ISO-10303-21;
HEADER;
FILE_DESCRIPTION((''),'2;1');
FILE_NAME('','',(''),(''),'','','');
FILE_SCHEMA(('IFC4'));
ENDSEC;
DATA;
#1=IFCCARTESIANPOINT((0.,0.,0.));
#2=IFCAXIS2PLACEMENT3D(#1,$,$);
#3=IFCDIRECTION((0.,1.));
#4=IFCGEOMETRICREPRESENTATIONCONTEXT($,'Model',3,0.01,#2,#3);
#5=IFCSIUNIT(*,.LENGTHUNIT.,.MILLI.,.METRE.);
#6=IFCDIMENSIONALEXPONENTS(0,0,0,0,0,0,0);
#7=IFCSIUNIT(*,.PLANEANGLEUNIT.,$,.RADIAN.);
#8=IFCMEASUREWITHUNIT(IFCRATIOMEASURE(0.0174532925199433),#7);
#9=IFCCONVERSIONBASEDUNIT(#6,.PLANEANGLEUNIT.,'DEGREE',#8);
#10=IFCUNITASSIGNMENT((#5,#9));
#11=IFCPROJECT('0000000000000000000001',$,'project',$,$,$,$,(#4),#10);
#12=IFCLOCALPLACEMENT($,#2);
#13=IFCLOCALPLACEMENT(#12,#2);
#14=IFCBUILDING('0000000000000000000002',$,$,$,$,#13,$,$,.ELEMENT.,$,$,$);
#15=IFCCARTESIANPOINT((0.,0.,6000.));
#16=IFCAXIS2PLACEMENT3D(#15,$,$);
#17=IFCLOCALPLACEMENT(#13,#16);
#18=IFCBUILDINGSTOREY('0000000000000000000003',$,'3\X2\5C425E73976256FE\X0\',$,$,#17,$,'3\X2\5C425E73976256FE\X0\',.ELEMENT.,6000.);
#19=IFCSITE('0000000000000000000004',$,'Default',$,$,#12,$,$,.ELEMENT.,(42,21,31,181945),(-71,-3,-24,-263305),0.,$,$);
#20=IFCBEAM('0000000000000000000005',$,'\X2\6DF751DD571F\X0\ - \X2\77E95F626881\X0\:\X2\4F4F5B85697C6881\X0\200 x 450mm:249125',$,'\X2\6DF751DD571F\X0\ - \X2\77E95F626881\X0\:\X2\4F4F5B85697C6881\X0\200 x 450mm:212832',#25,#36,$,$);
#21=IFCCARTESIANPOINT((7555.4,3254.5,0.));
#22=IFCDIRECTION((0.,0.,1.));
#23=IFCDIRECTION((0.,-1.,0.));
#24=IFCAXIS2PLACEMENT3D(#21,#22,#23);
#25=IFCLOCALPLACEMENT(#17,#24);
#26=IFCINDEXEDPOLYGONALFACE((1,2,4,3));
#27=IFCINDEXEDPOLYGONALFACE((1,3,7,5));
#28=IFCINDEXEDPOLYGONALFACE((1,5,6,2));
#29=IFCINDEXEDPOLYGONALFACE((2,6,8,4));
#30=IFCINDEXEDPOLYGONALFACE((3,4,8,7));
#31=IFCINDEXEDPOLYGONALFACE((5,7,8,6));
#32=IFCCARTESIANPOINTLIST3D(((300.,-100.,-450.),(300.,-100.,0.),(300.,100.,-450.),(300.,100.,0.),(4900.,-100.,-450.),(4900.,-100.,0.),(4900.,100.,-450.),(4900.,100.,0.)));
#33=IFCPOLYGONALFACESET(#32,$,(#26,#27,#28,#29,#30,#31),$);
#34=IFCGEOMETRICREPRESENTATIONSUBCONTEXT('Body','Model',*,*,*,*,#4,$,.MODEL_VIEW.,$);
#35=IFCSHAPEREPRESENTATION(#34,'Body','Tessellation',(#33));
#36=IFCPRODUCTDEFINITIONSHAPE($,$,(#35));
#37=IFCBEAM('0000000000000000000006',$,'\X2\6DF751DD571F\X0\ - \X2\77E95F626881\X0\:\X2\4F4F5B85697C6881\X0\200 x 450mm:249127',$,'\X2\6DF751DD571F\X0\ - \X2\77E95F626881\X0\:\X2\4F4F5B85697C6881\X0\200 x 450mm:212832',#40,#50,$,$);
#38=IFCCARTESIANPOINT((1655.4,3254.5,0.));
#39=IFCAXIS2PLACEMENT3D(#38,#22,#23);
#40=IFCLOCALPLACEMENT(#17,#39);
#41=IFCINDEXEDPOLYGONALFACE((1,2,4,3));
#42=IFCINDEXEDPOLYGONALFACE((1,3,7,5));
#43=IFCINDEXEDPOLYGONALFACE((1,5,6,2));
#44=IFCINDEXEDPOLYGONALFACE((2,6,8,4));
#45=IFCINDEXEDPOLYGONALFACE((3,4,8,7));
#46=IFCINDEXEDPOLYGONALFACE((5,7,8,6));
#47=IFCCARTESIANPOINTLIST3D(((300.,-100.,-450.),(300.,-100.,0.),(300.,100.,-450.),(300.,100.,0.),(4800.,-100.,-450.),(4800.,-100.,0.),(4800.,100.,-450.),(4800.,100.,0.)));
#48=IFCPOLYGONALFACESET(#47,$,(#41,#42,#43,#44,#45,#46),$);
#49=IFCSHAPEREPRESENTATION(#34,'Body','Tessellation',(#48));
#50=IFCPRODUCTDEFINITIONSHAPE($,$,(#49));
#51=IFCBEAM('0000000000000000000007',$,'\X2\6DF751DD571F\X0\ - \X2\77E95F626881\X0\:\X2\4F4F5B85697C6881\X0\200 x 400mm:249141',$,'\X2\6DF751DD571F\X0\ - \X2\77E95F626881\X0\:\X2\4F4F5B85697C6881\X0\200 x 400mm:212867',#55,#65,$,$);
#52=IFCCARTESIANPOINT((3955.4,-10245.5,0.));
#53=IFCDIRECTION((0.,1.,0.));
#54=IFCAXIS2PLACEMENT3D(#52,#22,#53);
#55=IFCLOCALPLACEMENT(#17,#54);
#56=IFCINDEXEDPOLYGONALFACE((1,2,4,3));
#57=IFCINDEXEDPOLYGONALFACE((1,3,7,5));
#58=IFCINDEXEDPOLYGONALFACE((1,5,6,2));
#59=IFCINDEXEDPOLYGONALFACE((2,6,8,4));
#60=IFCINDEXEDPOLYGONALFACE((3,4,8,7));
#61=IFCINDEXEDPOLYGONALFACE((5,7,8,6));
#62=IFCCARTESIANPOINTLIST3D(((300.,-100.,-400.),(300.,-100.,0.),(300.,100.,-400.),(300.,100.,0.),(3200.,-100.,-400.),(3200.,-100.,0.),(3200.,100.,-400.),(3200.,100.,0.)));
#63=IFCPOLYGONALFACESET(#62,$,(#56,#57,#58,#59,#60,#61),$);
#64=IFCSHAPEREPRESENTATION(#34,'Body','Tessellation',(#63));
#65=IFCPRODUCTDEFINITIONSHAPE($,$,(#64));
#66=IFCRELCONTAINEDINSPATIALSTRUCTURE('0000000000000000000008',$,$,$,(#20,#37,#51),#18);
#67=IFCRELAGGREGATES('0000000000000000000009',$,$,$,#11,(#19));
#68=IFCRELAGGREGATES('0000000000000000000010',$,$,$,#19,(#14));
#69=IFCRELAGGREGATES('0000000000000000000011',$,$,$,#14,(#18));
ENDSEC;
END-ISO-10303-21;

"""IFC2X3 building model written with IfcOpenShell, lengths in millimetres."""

from ifc_helpers import new_model, entity, si_unit, converted_unit, direction, frame, frame_2d, origin, origin_2d_with_axis, place, context, subcontext, project, spatial, rectangle, extrude, element, save


model = new_model("IFC2X3")

# Units and contexts
model_context = context("Model", 3, precision=0.01, world=origin(), true_north=direction((0.0, 1.0)))
body_context = subcontext(model_context, "Body", "Model", "MODEL_VIEW")
ifc_project = project(units=[si_unit("LENGTHUNIT", "METRE", prefix="MILLI"), converted_unit("PLANEANGLEUNIT", "DEGREE", entity("IfcRatioMeasure", 0.0174532925199433), si_unit("PLANEANGLEUNIT", "RADIAN"), dimensions=[0, 0, 0, 0, 0, 0, 0])], contexts=[model_context])

# Site, building, storey
site_placement = place(None, origin())
site = spatial("IfcSite", under=ifc_project, at=site_placement, Name="Default", CompositionType="ELEMENT", RefLatitude=(42, 21, 31, 181945), RefLongitude=(-71, -3, -24, -263305), RefElevation=0.0)
building_placement = place(site_placement, origin())
building = spatial("IfcBuilding", under=site, at=building_placement, CompositionType="ELEMENT")
storey_placement = place(building_placement, frame((0.0, 0.0, 6000.0)))
storey = spatial("IfcBuildingStorey", under=building, at=storey_placement, Name="3层平面图", LongName="3层平面图", CompositionType="ELEMENT", Elevation=6000.0)

# Beams
beam_1_placement = place(storey_placement, frame((7555.4, 3254.5, 0.0), z_axis=(0.0, 0.0, 1.0), x_axis=(0.0, -1.0, 0.0)))
element("IfcBeam", 1, at=beam_1_placement, inside=storey, Name="混凝土 - 矩形梁:住宅楼梁200 x 450mm:249125", ObjectType="混凝土 - 矩形梁:住宅楼梁200 x 450mm:212832", context=body_context, shape_type="SweptSolid", body=[
    extrude(rectangle(XDim=450.0, YDim=200.0, at=origin_2d_with_axis()), frame((300.0, 0.0, -225.0), z_axis=(1.0, 0.0, 0.0), x_axis=(0.0, 0.0, -1.0)), (0.0, 0.0, 1.0), 4600.0),
])
beam_2_placement = place(storey_placement, frame((1655.4, 3254.5, 0.0), z_axis=(0.0, 0.0, 1.0), x_axis=(0.0, -1.0, 0.0)))
element("IfcBeam", 2, at=beam_2_placement, inside=storey, Name="混凝土 - 矩形梁:住宅楼梁200 x 450mm:249127", ObjectType="混凝土 - 矩形梁:住宅楼梁200 x 450mm:212832", context=body_context, shape_type="SweptSolid", body=[
    extrude(rectangle(XDim=450.0, YDim=200.0, at=frame_2d((0.0, 0.0), x_axis=(1.0, 0.0))), frame((300.0, 0.0, -225.0), z_axis=(1.0, 0.0, 0.0), x_axis=(0.0, 0.0, -1.0)), (0.0, 0.0, 1.0), 4500.0),
])
beam_3_placement = place(storey_placement, frame((3955.4, -10245.5, 0.0), z_axis=(0.0, 0.0, 1.0), x_axis=(0.0, 1.0, 0.0)))
element("IfcBeam", 3, at=beam_3_placement, inside=storey, Name="混凝土 - 矩形梁:住宅楼梁200 x 400mm:249141", ObjectType="混凝土 - 矩形梁:住宅楼梁200 x 400mm:212867", context=body_context, shape_type="SweptSolid", body=[
    extrude(rectangle(XDim=400.0, YDim=200.0, at=frame_2d((0.0, 0.0), x_axis=(1.0, 0.0))), frame((300.0, 0.0, -200.0), z_axis=(1.0, 0.0, 0.0), x_axis=(0.0, 0.0, -1.0)), (0.0, 0.0, 1.0), 2900.0),
])

save(model, "model.ifc")
